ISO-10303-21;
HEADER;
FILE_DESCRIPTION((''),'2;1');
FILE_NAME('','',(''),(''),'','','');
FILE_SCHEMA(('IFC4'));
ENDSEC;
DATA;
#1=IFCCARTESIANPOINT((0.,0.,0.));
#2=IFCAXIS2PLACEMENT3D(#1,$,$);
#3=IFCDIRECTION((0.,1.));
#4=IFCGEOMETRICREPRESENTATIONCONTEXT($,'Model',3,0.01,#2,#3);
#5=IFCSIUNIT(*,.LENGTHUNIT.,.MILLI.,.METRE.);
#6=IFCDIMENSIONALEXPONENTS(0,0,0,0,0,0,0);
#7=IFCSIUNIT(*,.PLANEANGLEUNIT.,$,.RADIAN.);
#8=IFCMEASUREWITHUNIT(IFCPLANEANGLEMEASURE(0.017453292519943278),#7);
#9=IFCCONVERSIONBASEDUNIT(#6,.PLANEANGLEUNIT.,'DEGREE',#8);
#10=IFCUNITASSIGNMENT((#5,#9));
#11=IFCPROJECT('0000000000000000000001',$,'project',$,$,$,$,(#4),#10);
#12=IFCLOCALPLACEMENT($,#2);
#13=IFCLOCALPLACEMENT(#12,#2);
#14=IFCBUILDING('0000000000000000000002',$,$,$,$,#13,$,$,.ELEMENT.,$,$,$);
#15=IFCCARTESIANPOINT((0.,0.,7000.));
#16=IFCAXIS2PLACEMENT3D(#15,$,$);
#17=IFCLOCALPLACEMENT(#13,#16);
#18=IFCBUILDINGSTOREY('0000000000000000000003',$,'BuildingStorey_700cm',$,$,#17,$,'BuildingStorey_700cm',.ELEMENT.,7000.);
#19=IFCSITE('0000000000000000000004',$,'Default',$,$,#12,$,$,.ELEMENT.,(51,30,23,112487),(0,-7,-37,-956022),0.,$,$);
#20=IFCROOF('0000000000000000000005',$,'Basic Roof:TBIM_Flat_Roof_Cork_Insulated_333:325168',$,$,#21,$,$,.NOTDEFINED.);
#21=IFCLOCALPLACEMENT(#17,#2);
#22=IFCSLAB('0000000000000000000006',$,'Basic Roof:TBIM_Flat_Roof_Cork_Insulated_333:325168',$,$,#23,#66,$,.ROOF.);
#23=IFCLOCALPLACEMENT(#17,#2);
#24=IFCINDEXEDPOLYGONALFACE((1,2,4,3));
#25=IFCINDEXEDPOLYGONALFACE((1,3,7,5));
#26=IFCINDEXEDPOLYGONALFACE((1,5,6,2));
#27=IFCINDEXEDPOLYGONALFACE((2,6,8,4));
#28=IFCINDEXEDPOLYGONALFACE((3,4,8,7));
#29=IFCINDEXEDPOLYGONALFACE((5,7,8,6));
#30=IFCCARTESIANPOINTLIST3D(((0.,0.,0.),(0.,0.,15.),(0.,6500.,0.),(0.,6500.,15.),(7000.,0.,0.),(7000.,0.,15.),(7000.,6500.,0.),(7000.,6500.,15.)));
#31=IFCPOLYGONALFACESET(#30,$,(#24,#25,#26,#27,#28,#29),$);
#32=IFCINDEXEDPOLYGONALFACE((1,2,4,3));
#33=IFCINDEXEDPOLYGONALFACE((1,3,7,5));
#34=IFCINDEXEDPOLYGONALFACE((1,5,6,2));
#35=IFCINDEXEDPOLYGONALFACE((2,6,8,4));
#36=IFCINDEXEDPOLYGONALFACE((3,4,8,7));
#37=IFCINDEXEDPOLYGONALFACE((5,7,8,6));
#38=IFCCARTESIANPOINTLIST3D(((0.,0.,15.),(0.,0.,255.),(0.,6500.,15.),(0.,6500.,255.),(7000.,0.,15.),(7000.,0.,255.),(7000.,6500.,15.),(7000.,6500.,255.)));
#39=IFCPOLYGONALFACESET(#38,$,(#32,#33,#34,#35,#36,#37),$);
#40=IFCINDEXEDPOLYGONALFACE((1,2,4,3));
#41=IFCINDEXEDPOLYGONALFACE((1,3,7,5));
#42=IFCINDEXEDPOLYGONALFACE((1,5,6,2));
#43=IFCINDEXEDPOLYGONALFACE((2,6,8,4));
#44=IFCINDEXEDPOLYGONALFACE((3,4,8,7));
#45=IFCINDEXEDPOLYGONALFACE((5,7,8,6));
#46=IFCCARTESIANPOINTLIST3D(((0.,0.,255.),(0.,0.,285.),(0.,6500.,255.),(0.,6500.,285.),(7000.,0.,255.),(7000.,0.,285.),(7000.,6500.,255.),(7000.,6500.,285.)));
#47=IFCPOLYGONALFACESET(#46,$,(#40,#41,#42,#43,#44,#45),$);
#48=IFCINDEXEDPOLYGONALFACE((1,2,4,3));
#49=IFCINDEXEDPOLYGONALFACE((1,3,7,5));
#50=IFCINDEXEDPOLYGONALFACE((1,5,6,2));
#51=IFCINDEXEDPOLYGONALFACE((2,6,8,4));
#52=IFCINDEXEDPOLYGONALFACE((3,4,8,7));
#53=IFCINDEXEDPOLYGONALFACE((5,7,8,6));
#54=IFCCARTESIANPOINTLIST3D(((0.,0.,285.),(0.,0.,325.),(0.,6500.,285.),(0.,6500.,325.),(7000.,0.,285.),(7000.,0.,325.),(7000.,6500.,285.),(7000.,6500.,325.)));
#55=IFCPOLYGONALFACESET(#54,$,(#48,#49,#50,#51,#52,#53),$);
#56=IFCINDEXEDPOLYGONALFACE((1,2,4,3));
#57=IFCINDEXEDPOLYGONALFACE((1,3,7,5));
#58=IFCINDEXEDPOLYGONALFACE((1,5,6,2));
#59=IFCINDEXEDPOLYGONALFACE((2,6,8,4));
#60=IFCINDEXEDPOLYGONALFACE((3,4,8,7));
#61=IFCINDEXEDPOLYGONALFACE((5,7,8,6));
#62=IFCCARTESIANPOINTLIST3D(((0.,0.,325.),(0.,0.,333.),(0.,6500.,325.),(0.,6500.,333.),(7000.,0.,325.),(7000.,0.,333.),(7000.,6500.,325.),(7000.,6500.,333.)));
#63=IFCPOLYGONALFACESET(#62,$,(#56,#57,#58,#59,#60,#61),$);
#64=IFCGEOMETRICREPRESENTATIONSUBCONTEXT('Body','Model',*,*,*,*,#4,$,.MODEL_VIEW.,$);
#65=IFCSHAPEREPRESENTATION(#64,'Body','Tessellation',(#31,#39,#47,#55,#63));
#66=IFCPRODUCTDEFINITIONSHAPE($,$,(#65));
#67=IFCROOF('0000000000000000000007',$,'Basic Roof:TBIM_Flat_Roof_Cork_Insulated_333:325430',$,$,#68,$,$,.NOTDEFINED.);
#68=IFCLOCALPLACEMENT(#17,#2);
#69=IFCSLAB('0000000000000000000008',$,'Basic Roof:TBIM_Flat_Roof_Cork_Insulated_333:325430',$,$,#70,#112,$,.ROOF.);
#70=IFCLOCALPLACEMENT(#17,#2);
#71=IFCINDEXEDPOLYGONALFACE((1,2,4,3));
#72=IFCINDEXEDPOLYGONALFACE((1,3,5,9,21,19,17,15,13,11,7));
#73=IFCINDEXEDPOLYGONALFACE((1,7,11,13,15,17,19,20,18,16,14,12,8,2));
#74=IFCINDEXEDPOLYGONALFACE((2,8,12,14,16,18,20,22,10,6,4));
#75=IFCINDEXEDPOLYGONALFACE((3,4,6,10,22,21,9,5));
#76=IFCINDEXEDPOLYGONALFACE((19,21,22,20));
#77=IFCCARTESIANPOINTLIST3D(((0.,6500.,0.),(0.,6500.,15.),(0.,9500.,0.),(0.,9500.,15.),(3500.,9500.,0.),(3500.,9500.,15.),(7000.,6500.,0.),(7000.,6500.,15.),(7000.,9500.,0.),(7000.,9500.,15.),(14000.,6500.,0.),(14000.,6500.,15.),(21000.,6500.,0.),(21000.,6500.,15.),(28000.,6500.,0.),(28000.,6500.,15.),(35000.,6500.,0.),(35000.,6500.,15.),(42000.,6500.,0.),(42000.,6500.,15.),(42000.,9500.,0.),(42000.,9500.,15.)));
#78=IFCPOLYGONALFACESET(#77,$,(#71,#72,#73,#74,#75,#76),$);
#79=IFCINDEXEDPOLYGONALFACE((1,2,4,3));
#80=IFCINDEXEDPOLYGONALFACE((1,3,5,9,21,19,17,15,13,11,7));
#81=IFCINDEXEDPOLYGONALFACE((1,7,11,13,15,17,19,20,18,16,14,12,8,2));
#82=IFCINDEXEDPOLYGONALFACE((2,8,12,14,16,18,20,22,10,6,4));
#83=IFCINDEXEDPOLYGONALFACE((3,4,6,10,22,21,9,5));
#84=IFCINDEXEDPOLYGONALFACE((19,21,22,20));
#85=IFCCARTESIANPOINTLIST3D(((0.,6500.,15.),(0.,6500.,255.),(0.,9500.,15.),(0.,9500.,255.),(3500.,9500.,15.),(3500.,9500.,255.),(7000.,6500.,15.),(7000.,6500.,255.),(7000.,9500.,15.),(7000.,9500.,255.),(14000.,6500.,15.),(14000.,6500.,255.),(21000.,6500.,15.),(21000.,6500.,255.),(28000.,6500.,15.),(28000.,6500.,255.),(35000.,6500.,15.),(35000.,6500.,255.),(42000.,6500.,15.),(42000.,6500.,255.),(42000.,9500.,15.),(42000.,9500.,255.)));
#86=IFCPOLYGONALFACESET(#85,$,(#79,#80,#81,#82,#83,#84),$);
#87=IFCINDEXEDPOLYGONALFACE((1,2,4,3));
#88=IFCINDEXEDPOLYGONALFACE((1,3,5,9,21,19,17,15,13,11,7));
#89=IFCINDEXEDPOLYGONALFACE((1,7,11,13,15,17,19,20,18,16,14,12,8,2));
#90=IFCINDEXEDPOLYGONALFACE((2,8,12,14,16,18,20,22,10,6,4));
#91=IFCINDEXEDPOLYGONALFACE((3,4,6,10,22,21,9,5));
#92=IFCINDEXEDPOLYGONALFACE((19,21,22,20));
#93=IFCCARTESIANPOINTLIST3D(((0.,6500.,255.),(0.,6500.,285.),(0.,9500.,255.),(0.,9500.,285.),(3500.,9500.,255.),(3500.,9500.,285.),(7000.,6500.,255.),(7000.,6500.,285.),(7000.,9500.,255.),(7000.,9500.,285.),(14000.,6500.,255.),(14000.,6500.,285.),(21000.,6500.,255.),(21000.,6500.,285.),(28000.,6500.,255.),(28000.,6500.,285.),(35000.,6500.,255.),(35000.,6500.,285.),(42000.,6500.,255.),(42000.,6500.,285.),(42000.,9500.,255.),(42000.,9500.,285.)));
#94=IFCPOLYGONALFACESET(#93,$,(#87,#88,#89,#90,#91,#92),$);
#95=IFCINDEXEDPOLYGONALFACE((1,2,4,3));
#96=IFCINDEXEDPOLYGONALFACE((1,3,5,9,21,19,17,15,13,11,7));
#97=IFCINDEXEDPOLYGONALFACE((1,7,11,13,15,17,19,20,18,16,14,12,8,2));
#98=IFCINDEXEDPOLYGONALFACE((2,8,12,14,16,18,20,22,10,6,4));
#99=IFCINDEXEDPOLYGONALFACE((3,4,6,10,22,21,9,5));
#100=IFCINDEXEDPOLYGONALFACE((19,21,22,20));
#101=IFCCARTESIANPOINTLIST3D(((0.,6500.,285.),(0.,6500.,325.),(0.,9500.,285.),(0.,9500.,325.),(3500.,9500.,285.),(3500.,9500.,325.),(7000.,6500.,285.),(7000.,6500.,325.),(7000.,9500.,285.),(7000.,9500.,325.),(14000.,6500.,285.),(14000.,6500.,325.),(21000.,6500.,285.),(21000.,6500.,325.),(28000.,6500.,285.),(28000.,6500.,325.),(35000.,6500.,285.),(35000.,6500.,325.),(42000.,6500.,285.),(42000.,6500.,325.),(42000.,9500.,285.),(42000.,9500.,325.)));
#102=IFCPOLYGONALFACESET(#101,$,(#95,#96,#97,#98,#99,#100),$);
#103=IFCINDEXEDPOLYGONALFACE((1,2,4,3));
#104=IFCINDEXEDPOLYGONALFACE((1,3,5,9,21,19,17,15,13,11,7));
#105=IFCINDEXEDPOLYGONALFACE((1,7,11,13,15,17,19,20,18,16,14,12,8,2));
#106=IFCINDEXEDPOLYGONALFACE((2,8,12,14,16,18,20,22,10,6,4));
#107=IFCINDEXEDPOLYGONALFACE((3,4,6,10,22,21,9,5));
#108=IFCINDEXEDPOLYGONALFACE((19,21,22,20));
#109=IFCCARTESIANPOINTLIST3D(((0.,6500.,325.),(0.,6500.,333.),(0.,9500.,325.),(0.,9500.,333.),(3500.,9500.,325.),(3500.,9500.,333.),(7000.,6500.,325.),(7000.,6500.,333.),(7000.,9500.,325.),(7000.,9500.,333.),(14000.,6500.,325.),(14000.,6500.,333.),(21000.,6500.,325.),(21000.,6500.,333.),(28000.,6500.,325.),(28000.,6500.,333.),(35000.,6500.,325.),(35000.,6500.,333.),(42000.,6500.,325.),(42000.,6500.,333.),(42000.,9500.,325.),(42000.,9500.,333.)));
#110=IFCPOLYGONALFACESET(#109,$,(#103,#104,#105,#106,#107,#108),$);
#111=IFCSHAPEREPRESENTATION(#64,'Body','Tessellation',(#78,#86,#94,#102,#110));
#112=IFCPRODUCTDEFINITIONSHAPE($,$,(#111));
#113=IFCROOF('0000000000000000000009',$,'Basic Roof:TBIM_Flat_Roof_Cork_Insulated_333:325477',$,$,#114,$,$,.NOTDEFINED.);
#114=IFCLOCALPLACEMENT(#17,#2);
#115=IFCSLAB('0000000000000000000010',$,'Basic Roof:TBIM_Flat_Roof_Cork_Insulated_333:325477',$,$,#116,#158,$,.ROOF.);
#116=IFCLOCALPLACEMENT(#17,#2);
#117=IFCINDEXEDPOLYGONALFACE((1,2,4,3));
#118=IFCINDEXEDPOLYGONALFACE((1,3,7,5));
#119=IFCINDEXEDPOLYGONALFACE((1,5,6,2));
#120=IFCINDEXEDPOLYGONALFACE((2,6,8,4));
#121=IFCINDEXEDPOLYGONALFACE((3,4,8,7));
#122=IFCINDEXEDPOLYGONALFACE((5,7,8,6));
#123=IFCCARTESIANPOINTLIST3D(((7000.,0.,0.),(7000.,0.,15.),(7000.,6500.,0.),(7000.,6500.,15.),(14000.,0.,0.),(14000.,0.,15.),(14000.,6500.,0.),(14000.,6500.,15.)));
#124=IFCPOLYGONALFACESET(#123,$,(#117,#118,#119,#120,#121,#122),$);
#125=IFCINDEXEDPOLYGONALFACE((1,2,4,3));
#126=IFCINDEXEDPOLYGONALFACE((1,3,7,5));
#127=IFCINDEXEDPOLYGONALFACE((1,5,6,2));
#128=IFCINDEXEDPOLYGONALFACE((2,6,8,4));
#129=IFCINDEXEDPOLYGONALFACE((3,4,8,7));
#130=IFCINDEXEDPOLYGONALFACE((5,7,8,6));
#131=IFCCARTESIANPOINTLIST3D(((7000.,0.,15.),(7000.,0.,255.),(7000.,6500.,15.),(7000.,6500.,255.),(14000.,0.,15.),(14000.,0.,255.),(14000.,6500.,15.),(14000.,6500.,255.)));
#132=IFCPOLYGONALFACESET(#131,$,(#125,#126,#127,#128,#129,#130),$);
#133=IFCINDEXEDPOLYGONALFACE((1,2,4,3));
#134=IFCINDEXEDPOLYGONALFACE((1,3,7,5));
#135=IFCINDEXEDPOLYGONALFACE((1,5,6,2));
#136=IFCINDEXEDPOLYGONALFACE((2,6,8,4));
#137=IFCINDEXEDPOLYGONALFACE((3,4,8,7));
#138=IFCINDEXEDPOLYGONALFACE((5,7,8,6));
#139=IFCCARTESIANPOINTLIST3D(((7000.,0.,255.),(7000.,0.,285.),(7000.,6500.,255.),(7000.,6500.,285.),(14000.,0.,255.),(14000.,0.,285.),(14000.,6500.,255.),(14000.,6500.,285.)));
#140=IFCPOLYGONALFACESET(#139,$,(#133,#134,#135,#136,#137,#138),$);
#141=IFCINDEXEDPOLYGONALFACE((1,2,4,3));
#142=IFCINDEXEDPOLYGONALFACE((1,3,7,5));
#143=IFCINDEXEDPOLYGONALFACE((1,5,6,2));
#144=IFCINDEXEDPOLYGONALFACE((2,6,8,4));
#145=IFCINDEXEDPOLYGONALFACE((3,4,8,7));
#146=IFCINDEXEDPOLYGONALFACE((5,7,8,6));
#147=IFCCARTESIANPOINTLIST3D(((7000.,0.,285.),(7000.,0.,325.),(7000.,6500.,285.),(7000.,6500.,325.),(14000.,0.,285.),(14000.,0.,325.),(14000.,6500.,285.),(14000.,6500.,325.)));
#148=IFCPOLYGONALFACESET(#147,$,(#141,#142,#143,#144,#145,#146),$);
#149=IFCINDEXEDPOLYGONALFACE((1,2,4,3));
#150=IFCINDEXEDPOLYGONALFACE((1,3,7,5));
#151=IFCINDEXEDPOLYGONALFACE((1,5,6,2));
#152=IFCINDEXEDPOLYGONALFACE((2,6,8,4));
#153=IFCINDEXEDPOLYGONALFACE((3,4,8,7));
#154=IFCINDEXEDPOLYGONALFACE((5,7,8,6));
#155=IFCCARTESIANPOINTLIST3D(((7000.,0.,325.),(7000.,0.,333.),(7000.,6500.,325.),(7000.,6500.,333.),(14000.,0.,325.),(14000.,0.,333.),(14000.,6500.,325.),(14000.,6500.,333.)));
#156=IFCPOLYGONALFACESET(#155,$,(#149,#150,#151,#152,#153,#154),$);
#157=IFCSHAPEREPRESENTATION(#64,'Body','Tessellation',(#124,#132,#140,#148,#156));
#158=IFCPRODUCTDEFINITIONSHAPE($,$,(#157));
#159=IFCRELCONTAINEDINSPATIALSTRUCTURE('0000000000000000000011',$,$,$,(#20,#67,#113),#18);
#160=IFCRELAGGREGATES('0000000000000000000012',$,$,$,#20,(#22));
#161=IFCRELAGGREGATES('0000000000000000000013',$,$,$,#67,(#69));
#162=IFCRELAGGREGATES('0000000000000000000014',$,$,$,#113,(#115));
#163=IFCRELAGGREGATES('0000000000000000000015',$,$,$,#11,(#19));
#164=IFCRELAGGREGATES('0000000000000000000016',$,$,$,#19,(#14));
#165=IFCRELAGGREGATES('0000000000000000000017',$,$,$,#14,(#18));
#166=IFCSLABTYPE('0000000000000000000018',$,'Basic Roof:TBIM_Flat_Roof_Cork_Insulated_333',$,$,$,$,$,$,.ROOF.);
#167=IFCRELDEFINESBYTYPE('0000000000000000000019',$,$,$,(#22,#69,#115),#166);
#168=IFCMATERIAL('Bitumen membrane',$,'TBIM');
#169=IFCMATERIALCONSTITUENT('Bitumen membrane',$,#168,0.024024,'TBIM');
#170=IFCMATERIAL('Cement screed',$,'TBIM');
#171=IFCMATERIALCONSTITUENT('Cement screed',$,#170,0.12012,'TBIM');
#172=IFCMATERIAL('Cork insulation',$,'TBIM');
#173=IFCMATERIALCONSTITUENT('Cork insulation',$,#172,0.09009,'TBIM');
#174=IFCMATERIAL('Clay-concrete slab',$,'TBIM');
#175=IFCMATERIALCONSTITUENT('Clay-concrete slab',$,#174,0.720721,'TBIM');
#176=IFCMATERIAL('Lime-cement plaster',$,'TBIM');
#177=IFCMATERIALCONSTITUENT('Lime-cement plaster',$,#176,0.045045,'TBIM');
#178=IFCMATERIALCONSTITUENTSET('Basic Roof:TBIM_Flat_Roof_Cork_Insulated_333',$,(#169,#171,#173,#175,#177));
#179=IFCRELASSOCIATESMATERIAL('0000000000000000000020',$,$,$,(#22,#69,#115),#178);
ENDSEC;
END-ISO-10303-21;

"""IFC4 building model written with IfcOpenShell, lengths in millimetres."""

from ifc_helpers import new_model, entity, si_unit, converted_unit, direction, frame, origin, place, context, subcontext, project, spatial, indexed_curve, outline, extrude, material, constituent, constituent_set, type_object, element, aggregate, save


model = new_model("IFC4")

# Units and contexts
model_context = context("Model", 3, precision=0.01, world=origin(), true_north=direction((0.0, 1.0)))
body_context = subcontext(model_context, "Body", "Model", "MODEL_VIEW")
ifc_project = project(units=[si_unit("LENGTHUNIT", "METRE", prefix="MILLI"), converted_unit("PLANEANGLEUNIT", "DEGREE", entity("IfcPlaneAngleMeasure", 0.017453292519943278), si_unit("PLANEANGLEUNIT", "RADIAN"), dimensions=[0, 0, 0, 0, 0, 0, 0])], contexts=[model_context])

# Site, building, storey
site_placement = place(None, origin())
site = spatial("IfcSite", under=ifc_project, at=site_placement, Name="Default", CompositionType="ELEMENT", RefLatitude=(51, 30, 23, 112487), RefLongitude=(0, -7, -37, -956022), RefElevation=0.0)
building_placement = place(site_placement, origin())
building = spatial("IfcBuilding", under=site, at=building_placement, CompositionType="ELEMENT")
storey_placement = place(building_placement, frame((0.0, 0.0, 7000.0)))
storey = spatial("IfcBuildingStorey", under=building, at=storey_placement, Name="BuildingStorey_700cm", LongName="BuildingStorey_700cm", CompositionType="ELEMENT", Elevation=7000.0)

# Roofs, slabs
roof_1_placement = place(storey_placement, origin())
roof_1 = element("IfcRoof", 1, at=roof_1_placement, inside=storey, Name="Basic Roof:TBIM_Flat_Roof_Cork_Insulated_333:325168", PredefinedType="NOTDEFINED")
ifc_material_1 = material(Name="Bitumen membrane", Category="TBIM")
ifc_constituent_1 = constituent(ifc_material_1, Name="Bitumen membrane", Category="TBIM", fraction=0.024024)
ifc_material_2 = material(Name="Cement screed", Category="TBIM")
ifc_constituent_2 = constituent(ifc_material_2, Name="Cement screed", Category="TBIM", fraction=0.12012)
ifc_material_3 = material(Name="Cork insulation", Category="TBIM")
ifc_constituent_3 = constituent(ifc_material_3, Name="Cork insulation", Category="TBIM", fraction=0.09009)
ifc_material_4 = material(Name="Clay-concrete slab", Category="TBIM")
ifc_constituent_4 = constituent(ifc_material_4, Name="Clay-concrete slab", Category="TBIM", fraction=0.720721)
ifc_material_5 = material(Name="Lime-cement plaster", Category="TBIM")
ifc_constituent_5 = constituent(ifc_material_5, Name="Lime-cement plaster", Category="TBIM", fraction=0.045045)
ifc_constituent_set = constituent_set(constituents=[ifc_constituent_1, ifc_constituent_2, ifc_constituent_3, ifc_constituent_4, ifc_constituent_5], Name="Basic Roof:TBIM_Flat_Roof_Cork_Insulated_333")
slab_type = type_object("IfcSlabType", Name="Basic Roof:TBIM_Flat_Roof_Cork_Insulated_333", PredefinedType="ROOF")
slab_1_placement = place(roof_1_placement, origin())
slab_1 = element("IfcSlab", 2, at=slab_1_placement, type_object=slab_type, material=ifc_constituent_set, Name="Basic Roof:TBIM_Flat_Roof_Cork_Insulated_333:325168", PredefinedType="ROOF", context=body_context, shape_type="SweptSolid", body=[
    extrude(outline(indexed_curve([(-3500.0, 3250.0), (-3500.0, -3250.0), (3500.0, -3250.0), (3500.0, 3250.0), (-3500.0, 3250.0)], self_intersect=False)), frame((3500.0, 3250.0, 0.0)), (0.0, 0.0, 1.0), 15.0),
    extrude(outline(indexed_curve([(-3500.0, 3250.0), (-3500.0, -3250.0), (3500.0, -3250.0), (3500.0, 3250.0), (-3500.0, 3250.0)], self_intersect=False)), frame((3500.0, 3250.0, 15.0)), (0.0, 0.0, 1.0), 240.0),
    extrude(outline(indexed_curve([(-3500.0, 3250.0), (-3500.0, -3250.0), (3500.0, -3250.0), (3500.0, 3250.0), (-3500.0, 3250.0)], self_intersect=False)), frame((3500.0, 3250.0, 255.0)), (0.0, 0.0, 1.0), 30.0),
    extrude(outline(indexed_curve([(-3500.0, 3250.0), (-3500.0, -3250.0), (3500.0, -3250.0), (3500.0, 3250.0), (-3500.0, 3250.0)], self_intersect=False)), frame((3500.0, 3250.0, 285.0)), (0.0, 0.0, 1.0), 40.0),
    extrude(outline(indexed_curve([(-3500.0, 3250.0), (-3500.0, -3250.0), (3500.0, -3250.0), (3500.0, 3250.0), (-3500.0, 3250.0)], self_intersect=False)), frame((3500.0, 3250.0, 325.0)), (0.0, 0.0, 1.0), 8.0),
])
aggregate(roof_1, [slab_1])
roof_2_placement = place(storey_placement, frame((0.0, 6500.0, 0.0)))
roof_2 = element("IfcRoof", 3, at=roof_2_placement, inside=storey, Name="Basic Roof:TBIM_Flat_Roof_Cork_Insulated_333:325430", PredefinedType="NOTDEFINED")
slab_2_placement = place(roof_2_placement, origin())
slab_2 = element("IfcSlab", 4, at=slab_2_placement, type_object=slab_type, material=ifc_constituent_set, Name="Basic Roof:TBIM_Flat_Roof_Cork_Insulated_333:325430", PredefinedType="ROOF", context=body_context, shape_type="SweptSolid", body=[
    extrude(outline(indexed_curve([(-21000.0, 1500.0), (-21000.0, -1500.0), (-14000.0, -1500.0), (-7000.0, -1500.0), (0.0, -1500.0), (7000.0, -1500.0), (14000.0, -1500.0), (21000.0, -1500.0), (21000.0, 1500.0), (-14000.0, 1500.0), (-17500.0, 1500.0), (-21000.0, 1500.0)], self_intersect=False)), frame((21000.0, 1500.0, 0.0)), (0.0, 0.0, 1.0), 15.0),
    extrude(outline(indexed_curve([(-21000.0, 1500.0), (-21000.0, -1500.0), (-14000.0, -1500.0), (-7000.0, -1500.0), (0.0, -1500.0), (7000.0, -1500.0), (14000.0, -1500.0), (21000.0, -1500.0), (21000.0, 1500.0), (-14000.0, 1500.0), (-17500.0, 1500.0), (-21000.0, 1500.0)], self_intersect=False)), frame((21000.0, 1500.0, 15.0)), (0.0, 0.0, 1.0), 240.0),
    extrude(outline(indexed_curve([(-21000.0, 1500.0), (-21000.0, -1500.0), (-14000.0, -1500.0), (-7000.0, -1500.0), (0.0, -1500.0), (7000.0, -1500.0), (14000.0, -1500.0), (21000.0, -1500.0), (21000.0, 1500.0), (-14000.0, 1500.0), (-17500.0, 1500.0), (-21000.0, 1500.0)], self_intersect=False)), frame((21000.0, 1500.0, 255.0)), (0.0, 0.0, 1.0), 30.0),
    extrude(outline(indexed_curve([(-21000.0, 1500.0), (-21000.0, -1500.0), (-14000.0, -1500.0), (-7000.0, -1500.0), (0.0, -1500.0), (7000.0, -1500.0), (14000.0, -1500.0), (21000.0, -1500.0), (21000.0, 1500.0), (-14000.0, 1500.0), (-17500.0, 1500.0), (-21000.0, 1500.0)], self_intersect=False)), frame((21000.0, 1500.0, 285.0)), (0.0, 0.0, 1.0), 40.0),
    extrude(outline(indexed_curve([(-21000.0, 1500.0), (-21000.0, -1500.0), (-14000.0, -1500.0), (-7000.0, -1500.0), (0.0, -1500.0), (7000.0, -1500.0), (14000.0, -1500.0), (21000.0, -1500.0), (21000.0, 1500.0), (-14000.0, 1500.0), (-17500.0, 1500.0), (-21000.0, 1500.0)], self_intersect=False)), frame((21000.0, 1500.0, 325.0)), (0.0, 0.0, 1.0), 8.0),
])
aggregate(roof_2, [slab_2])
roof_3_placement = place(storey_placement, frame((7000.0, 0.0, 0.0)))
roof_3 = element("IfcRoof", 5, at=roof_3_placement, inside=storey, Name="Basic Roof:TBIM_Flat_Roof_Cork_Insulated_333:325477", PredefinedType="NOTDEFINED")
slab_3_placement = place(roof_3_placement, origin())
slab_3 = element("IfcSlab", 6, at=slab_3_placement, type_object=slab_type, material=ifc_constituent_set, Name="Basic Roof:TBIM_Flat_Roof_Cork_Insulated_333:325477", PredefinedType="ROOF", context=body_context, shape_type="SweptSolid", body=[
    extrude(outline(indexed_curve([(-3500.0, 3250.0), (-3500.0, -3250.0), (3500.0, -3250.0), (3500.0, 3250.0), (-3500.0, 3250.0)], self_intersect=False)), frame((3500.0, 3250.0, 0.0)), (0.0, 0.0, 1.0), 15.0),
    extrude(outline(indexed_curve([(-3500.0, 3250.0), (-3500.0, -3250.0), (3500.0, -3250.0), (3500.0, 3250.0), (-3500.0, 3250.0)], self_intersect=False)), frame((3500.0, 3250.0, 15.0)), (0.0, 0.0, 1.0), 240.0),
    extrude(outline(indexed_curve([(-3500.0, 3250.0), (-3500.0, -3250.0), (3500.0, -3250.0), (3500.0, 3250.0), (-3500.0, 3250.0)], self_intersect=False)), frame((3500.0, 3250.0, 255.0)), (0.0, 0.0, 1.0), 30.0),
    extrude(outline(indexed_curve([(-3500.0, 3250.0), (-3500.0, -3250.0), (3500.0, -3250.0), (3500.0, 3250.0), (-3500.0, 3250.0)], self_intersect=False)), frame((3500.0, 3250.0, 285.0)), (0.0, 0.0, 1.0), 40.0),
    extrude(outline(indexed_curve([(-3500.0, 3250.0), (-3500.0, -3250.0), (3500.0, -3250.0), (3500.0, 3250.0), (-3500.0, 3250.0)], self_intersect=False)), frame((3500.0, 3250.0, 325.0)), (0.0, 0.0, 1.0), 8.0),
])
aggregate(roof_3, [slab_3])

save(model, "model.ifc")
